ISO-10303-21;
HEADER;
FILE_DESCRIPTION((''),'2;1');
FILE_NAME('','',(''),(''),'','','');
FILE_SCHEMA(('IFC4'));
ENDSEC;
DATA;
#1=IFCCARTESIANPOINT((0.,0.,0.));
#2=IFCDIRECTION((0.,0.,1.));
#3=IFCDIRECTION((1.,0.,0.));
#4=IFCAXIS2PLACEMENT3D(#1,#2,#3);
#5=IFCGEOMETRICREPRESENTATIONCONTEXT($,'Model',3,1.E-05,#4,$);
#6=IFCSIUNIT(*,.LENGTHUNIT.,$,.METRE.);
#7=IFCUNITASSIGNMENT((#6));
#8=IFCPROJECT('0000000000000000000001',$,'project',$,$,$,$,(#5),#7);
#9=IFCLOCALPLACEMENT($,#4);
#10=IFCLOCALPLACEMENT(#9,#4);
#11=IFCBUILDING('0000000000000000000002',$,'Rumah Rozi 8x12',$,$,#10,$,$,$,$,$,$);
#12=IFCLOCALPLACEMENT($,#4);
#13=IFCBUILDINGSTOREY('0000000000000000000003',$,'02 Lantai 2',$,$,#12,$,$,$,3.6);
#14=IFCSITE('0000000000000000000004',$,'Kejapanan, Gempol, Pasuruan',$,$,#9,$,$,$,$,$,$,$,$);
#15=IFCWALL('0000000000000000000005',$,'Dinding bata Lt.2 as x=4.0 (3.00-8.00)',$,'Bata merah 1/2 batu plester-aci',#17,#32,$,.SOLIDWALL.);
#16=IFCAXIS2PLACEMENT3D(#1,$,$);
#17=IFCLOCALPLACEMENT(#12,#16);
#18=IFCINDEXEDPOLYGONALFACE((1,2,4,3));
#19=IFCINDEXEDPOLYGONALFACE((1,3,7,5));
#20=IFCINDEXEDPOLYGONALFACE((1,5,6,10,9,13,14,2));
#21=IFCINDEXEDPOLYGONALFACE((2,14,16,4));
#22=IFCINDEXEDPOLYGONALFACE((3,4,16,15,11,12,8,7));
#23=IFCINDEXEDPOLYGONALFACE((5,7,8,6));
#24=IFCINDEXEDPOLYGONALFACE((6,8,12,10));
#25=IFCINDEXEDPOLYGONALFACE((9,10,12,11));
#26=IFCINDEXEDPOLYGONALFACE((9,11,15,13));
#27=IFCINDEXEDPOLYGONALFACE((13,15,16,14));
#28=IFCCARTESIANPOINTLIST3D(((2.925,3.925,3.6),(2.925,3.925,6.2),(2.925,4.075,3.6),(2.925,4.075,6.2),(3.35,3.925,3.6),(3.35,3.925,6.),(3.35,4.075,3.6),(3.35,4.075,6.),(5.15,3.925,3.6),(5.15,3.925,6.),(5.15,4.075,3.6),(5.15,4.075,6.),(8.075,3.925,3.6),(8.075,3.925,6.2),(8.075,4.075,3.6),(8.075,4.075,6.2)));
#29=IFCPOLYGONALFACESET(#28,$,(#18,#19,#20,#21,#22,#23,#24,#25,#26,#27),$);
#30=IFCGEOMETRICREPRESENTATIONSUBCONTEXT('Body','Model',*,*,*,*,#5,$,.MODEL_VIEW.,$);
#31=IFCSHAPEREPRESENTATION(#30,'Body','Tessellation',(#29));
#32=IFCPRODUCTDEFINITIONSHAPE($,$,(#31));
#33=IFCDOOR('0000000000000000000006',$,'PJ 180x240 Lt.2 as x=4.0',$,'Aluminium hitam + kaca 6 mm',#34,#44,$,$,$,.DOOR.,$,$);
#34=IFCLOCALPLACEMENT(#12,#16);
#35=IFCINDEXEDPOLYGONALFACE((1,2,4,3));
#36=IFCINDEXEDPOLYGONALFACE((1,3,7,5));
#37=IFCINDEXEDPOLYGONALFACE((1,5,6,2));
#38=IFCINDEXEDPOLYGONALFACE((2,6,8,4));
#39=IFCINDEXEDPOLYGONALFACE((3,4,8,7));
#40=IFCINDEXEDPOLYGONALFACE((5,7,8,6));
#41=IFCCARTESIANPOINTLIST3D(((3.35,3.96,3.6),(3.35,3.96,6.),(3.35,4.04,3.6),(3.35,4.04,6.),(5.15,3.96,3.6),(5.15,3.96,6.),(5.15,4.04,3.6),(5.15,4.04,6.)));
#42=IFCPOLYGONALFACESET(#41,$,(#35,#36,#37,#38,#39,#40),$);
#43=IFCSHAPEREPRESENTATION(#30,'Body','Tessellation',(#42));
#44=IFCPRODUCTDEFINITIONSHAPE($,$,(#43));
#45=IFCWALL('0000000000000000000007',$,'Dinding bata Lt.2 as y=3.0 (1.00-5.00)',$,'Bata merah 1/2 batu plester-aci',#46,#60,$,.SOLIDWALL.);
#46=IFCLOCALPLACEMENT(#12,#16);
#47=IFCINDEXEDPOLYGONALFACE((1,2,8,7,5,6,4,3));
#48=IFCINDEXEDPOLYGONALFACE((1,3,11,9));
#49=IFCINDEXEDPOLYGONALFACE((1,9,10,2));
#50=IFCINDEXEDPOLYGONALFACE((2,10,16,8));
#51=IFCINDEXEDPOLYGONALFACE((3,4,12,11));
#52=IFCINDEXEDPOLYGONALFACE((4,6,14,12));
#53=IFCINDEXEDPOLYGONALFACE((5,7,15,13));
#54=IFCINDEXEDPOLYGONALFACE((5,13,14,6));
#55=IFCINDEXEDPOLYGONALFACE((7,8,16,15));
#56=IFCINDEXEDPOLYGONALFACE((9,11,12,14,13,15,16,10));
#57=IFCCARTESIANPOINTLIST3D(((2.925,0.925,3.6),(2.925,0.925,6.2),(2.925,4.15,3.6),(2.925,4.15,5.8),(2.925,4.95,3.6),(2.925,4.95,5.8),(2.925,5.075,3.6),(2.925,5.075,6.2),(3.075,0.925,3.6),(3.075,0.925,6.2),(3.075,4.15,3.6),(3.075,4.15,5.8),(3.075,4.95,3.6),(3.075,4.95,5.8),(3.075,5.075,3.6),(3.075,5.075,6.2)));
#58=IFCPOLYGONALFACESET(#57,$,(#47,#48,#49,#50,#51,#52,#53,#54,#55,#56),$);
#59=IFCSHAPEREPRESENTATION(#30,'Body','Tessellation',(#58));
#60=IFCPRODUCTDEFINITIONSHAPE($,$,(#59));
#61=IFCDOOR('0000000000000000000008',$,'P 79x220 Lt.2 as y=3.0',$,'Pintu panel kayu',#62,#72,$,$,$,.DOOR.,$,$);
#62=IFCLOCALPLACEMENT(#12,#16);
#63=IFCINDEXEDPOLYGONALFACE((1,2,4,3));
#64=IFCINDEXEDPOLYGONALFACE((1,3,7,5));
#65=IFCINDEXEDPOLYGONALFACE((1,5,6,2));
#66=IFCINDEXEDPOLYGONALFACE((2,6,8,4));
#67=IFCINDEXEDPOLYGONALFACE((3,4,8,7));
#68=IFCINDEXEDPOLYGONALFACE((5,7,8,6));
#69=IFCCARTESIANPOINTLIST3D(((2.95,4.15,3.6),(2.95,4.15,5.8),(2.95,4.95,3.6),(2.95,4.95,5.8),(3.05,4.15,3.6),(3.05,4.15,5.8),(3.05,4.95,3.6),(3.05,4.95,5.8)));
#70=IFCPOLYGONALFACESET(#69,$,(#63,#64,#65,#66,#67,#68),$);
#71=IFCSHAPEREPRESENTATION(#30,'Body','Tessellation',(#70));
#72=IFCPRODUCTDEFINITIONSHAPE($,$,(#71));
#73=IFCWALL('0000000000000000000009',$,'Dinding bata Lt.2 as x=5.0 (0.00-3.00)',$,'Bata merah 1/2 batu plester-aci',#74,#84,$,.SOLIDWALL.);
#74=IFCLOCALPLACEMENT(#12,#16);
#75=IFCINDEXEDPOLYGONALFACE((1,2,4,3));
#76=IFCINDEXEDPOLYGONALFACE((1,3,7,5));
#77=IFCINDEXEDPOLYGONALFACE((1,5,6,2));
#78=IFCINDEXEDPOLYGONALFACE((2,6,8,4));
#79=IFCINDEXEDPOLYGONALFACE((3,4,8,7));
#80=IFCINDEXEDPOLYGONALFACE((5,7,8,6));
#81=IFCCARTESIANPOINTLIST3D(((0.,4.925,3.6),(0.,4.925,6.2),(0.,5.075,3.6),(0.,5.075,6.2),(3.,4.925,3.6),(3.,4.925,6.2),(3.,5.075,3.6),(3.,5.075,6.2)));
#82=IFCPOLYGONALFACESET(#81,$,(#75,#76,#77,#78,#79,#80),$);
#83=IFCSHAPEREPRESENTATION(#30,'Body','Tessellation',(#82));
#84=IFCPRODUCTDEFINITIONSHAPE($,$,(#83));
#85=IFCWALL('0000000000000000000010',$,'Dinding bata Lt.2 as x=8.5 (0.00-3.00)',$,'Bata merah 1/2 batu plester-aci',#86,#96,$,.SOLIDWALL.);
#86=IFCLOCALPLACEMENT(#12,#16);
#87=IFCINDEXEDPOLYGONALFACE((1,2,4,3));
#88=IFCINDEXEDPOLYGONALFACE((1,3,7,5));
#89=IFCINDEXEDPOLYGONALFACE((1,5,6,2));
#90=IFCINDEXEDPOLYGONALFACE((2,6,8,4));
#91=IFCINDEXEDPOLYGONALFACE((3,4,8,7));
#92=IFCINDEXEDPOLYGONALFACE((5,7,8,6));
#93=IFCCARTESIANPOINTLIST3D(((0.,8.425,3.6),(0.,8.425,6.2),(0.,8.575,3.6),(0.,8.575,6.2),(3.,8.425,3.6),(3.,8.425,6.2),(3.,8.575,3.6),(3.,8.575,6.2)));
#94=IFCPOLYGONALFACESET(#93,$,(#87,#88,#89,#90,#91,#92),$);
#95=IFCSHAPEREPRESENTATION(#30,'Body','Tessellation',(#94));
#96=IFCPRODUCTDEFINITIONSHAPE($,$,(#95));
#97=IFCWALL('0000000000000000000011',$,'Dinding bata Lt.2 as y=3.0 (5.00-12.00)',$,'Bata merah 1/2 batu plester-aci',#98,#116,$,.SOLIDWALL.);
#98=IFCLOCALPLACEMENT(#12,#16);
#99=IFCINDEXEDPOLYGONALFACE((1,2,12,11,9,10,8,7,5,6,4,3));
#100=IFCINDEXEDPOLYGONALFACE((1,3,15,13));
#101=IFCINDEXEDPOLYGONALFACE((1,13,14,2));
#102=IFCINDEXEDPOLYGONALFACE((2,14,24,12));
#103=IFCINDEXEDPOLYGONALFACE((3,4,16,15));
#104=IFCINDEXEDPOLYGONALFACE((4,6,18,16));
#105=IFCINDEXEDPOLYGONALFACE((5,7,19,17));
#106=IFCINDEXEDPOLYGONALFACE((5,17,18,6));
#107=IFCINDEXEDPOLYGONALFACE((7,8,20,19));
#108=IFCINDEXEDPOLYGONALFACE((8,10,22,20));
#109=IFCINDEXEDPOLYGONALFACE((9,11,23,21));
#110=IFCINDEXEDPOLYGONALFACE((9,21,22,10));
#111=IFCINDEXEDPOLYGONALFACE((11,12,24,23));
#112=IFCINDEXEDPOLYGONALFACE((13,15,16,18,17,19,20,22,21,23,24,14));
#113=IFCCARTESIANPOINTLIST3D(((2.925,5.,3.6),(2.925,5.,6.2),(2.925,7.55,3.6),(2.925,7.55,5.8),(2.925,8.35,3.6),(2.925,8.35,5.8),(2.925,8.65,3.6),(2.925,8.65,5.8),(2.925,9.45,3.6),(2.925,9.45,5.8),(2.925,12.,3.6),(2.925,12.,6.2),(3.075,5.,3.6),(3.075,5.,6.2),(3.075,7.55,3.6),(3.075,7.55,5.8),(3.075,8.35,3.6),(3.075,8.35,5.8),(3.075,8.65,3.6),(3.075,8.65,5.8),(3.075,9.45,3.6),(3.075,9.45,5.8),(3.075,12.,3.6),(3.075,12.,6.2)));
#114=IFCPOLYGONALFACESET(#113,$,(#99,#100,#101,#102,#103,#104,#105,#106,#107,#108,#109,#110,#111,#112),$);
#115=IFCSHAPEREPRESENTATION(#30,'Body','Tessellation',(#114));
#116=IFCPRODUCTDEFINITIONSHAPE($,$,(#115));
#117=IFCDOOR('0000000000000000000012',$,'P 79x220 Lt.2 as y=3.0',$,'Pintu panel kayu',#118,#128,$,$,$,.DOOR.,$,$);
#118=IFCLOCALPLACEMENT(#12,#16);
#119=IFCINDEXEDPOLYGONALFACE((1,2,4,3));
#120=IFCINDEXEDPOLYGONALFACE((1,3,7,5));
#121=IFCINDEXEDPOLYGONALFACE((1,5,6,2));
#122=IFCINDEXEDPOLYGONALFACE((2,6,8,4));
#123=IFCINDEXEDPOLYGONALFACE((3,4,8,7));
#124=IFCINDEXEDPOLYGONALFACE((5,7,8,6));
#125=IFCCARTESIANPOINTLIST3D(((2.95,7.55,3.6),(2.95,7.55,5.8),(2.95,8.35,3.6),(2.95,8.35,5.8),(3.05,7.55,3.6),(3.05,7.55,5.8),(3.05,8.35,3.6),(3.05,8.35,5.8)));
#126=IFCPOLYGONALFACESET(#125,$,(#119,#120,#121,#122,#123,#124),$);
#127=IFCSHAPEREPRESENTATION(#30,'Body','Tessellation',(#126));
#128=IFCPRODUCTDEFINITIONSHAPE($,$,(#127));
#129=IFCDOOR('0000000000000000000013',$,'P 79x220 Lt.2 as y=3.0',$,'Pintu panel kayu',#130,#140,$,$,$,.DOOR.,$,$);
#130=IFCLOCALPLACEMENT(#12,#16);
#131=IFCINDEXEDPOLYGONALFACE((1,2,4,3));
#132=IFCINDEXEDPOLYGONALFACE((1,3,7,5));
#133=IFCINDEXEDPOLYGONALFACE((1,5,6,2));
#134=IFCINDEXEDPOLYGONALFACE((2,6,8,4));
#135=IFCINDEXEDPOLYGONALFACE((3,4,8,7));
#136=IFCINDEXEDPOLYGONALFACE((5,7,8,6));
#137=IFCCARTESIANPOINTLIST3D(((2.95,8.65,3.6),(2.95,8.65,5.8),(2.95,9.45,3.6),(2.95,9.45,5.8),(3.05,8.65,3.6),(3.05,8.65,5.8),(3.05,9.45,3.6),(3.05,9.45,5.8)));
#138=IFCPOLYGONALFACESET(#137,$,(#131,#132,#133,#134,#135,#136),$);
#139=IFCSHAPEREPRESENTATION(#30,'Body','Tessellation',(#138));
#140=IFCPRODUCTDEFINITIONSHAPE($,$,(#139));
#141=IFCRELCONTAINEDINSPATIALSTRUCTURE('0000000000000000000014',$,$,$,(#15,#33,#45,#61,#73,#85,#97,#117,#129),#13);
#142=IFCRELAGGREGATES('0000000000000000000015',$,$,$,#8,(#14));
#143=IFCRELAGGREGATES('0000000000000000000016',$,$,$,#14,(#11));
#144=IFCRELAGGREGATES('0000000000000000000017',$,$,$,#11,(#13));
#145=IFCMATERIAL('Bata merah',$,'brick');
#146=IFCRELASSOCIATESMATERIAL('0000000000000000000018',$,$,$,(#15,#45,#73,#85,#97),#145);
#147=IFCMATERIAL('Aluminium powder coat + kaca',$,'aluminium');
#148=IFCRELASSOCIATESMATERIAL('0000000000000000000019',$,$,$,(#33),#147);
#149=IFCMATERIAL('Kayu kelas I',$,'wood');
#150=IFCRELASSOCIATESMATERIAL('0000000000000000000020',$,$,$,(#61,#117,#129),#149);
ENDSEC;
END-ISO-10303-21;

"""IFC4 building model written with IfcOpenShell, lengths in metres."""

from ifc_helpers import new_model, si_unit, frame, origin_with_axes, place, context, subcontext, project, spatial, line, indexed_curve, outline, extrude, material, element, fill, save


model = new_model("IFC4")

# Units and contexts
model_context = context("Model", 3, precision=1e-05, world=origin_with_axes())
body_context = subcontext(model_context, "Body", "Model", "MODEL_VIEW")
ifc_project = project(units=[si_unit("LENGTHUNIT", "METRE")], contexts=[model_context])

# Site, building, storey
site_placement = place(None, origin_with_axes())
site = spatial("IfcSite", under=ifc_project, at=site_placement, Name="Kejapanan, Gempol, Pasuruan")
building_placement = place(site_placement, origin_with_axes())
building = spatial("IfcBuilding", under=site, at=building_placement, Name="Rumah Rozi 8x12")
storey_placement = place(None, origin_with_axes())
storey = spatial("IfcBuildingStorey", under=building, at=storey_placement, Name="02 Lantai 2", Elevation=3.6)

# Shared definitions
ifc_material_1 = material(Name="Bata merah", Category="brick")
ifc_material_2 = material(Name="Aluminium powder coat + kaca", Category="aluminium")

# Walls, openings, doors
wall_1_placement = place(storey_placement, origin_with_axes())
wall_1 = element("IfcWall", 1, at=wall_1_placement, inside=storey, material=ifc_material_1, Name="Dinding bata Lt.2 as x=4.0 (3.00-8.00)", ObjectType="Bata merah 1/2 batu plester-aci", PredefinedType="SOLIDWALL", context=body_context, shape_type="SweptSolid", body=[
    extrude(outline(indexed_curve([(2.925, 3.925), (8.075, 3.925), (8.075, 4.075), (2.925, 4.075)], segments=[line(1, 2, 3, 4, 1)])), frame((0.0, 0.0, 3.6), z_axis=(0.0, 0.0, 1.0), x_axis=(1.0, 0.0, 0.0)), (0.0, 0.0, 1.0), 2.6),
])
opening_1_placement = place(wall_1_placement, origin_with_axes())
opening_1 = element("IfcOpeningElement", 2, at=opening_1_placement, cuts=wall_1, context=body_context, shape_type="SweptSolid", body=[
    extrude(outline(indexed_curve([(3.35, 3.915), (5.15, 3.915), (5.15, 4.085), (3.35, 4.085)], segments=[line(1, 2, 3, 4, 1)])), frame((0.0, 0.0, 3.6), z_axis=(0.0, 0.0, 1.0), x_axis=(1.0, 0.0, 0.0)), (0.0, 0.0, 1.0), 2.4),
])
door_1_placement = place(storey_placement, origin_with_axes())
door_1 = element("IfcDoor", 3, at=door_1_placement, inside=storey, material=ifc_material_2, Name="PJ 180x240 Lt.2 as x=4.0", ObjectType="Aluminium hitam + kaca 6 mm", PredefinedType="DOOR", context=body_context, shape_type="SweptSolid", body=[
    extrude(outline(indexed_curve([(3.35, 3.96), (5.15, 3.96), (5.15, 4.04), (3.35, 4.04)], segments=[line(1, 2, 3, 4, 1)])), frame((0.0, 0.0, 3.6), z_axis=(0.0, 0.0, 1.0), x_axis=(1.0, 0.0, 0.0)), (0.0, 0.0, 1.0), 2.4),
])
fill(opening_1, door_1)
wall_2_placement = place(storey_placement, origin_with_axes())
wall_2 = element("IfcWall", 4, at=wall_2_placement, inside=storey, material=ifc_material_1, Name="Dinding bata Lt.2 as y=3.0 (1.00-5.00)", ObjectType="Bata merah 1/2 batu plester-aci", PredefinedType="SOLIDWALL", context=body_context, shape_type="SweptSolid", body=[
    extrude(outline(indexed_curve([(2.925, 0.925), (3.075, 0.925), (3.075, 5.075), (2.925, 5.075)], segments=[line(1, 2, 3, 4, 1)])), frame((0.0, 0.0, 3.6), z_axis=(0.0, 0.0, 1.0), x_axis=(1.0, 0.0, 0.0)), (0.0, 0.0, 1.0), 2.6),
])
opening_2_placement = place(wall_2_placement, origin_with_axes())
opening_2 = element("IfcOpeningElement", 5, at=opening_2_placement, cuts=wall_2, context=body_context, shape_type="SweptSolid", body=[
    extrude(outline(indexed_curve([(2.915, 4.15), (3.085, 4.15), (3.085, 4.95), (2.915, 4.95)], segments=[line(1, 2, 3, 4, 1)])), frame((0.0, 0.0, 3.6), z_axis=(0.0, 0.0, 1.0), x_axis=(1.0, 0.0, 0.0)), (0.0, 0.0, 1.0), 2.2),
])
ifc_material_3 = material(Name="Kayu kelas I", Category="wood")
door_2_placement = place(storey_placement, origin_with_axes())
door_2 = element("IfcDoor", 6, at=door_2_placement, inside=storey, material=ifc_material_3, Name="P 79x220 Lt.2 as y=3.0", ObjectType="Pintu panel kayu", PredefinedType="DOOR", context=body_context, shape_type="SweptSolid", body=[
    extrude(outline(indexed_curve([(2.95, 4.15), (3.05, 4.15), (3.05, 4.95), (2.95, 4.95)], segments=[line(1, 2, 3, 4, 1)])), frame((0.0, 0.0, 3.6), z_axis=(0.0, 0.0, 1.0), x_axis=(1.0, 0.0, 0.0)), (0.0, 0.0, 1.0), 2.2),
])
fill(opening_2, door_2)

# Walls
wall_3_placement = place(storey_placement, origin_with_axes())
element("IfcWall", 7, at=wall_3_placement, inside=storey, material=ifc_material_1, Name="Dinding bata Lt.2 as x=5.0 (0.00-3.00)", ObjectType="Bata merah 1/2 batu plester-aci", PredefinedType="SOLIDWALL", context=body_context, shape_type="SweptSolid", body=[
    extrude(outline(indexed_curve([(0.0, 4.925), (3.0, 4.925), (3.0, 5.075), (0.0, 5.075)], segments=[line(1, 2, 3, 4, 1)])), frame((0.0, 0.0, 3.6), z_axis=(0.0, 0.0, 1.0), x_axis=(1.0, 0.0, 0.0)), (0.0, 0.0, 1.0), 2.6),
])
wall_4_placement = place(storey_placement, origin_with_axes())
element("IfcWall", 8, at=wall_4_placement, inside=storey, material=ifc_material_1, Name="Dinding bata Lt.2 as x=8.5 (0.00-3.00)", ObjectType="Bata merah 1/2 batu plester-aci", PredefinedType="SOLIDWALL", context=body_context, shape_type="SweptSolid", body=[
    extrude(outline(indexed_curve([(0.0, 8.425), (3.0, 8.425), (3.0, 8.575), (0.0, 8.575)], segments=[line(1, 2, 3, 4, 1)])), frame((0.0, 0.0, 3.6), z_axis=(0.0, 0.0, 1.0), x_axis=(1.0, 0.0, 0.0)), (0.0, 0.0, 1.0), 2.6),
])

# Wall, openings, doors
wall_5_placement = place(storey_placement, origin_with_axes())
wall_5 = element("IfcWall", 9, at=wall_5_placement, inside=storey, material=ifc_material_1, Name="Dinding bata Lt.2 as y=3.0 (5.00-12.00)", ObjectType="Bata merah 1/2 batu plester-aci", PredefinedType="SOLIDWALL", context=body_context, shape_type="SweptSolid", body=[
    extrude(outline(indexed_curve([(2.925, 5.0), (3.075, 5.0), (3.075, 12.0), (2.925, 12.0)], segments=[line(1, 2, 3, 4, 1)])), frame((0.0, 0.0, 3.6), z_axis=(0.0, 0.0, 1.0), x_axis=(1.0, 0.0, 0.0)), (0.0, 0.0, 1.0), 2.6),
])
opening_3_placement = place(wall_5_placement, origin_with_axes())
opening_3 = element("IfcOpeningElement", 10, at=opening_3_placement, cuts=wall_5, context=body_context, shape_type="SweptSolid", body=[
    extrude(outline(indexed_curve([(2.915, 7.55), (3.085, 7.55), (3.085, 8.35), (2.915, 8.35)], segments=[line(1, 2, 3, 4, 1)])), frame((0.0, 0.0, 3.6), z_axis=(0.0, 0.0, 1.0), x_axis=(1.0, 0.0, 0.0)), (0.0, 0.0, 1.0), 2.2),
])
opening_4_placement = place(wall_5_placement, origin_with_axes())
opening_4 = element("IfcOpeningElement", 11, at=opening_4_placement, cuts=wall_5, context=body_context, shape_type="SweptSolid", body=[
    extrude(outline(indexed_curve([(2.915, 8.65), (3.085, 8.65), (3.085, 9.45), (2.915, 9.45)], segments=[line(1, 2, 3, 4, 1)])), frame((0.0, 0.0, 3.6), z_axis=(0.0, 0.0, 1.0), x_axis=(1.0, 0.0, 0.0)), (0.0, 0.0, 1.0), 2.2),
])
door_3_placement = place(storey_placement, origin_with_axes())
door_3 = element("IfcDoor", 12, at=door_3_placement, inside=storey, material=ifc_material_3, Name="P 79x220 Lt.2 as y=3.0", ObjectType="Pintu panel kayu", PredefinedType="DOOR", context=body_context, shape_type="SweptSolid", body=[
    extrude(outline(indexed_curve([(2.95, 7.55), (3.05, 7.55), (3.05, 8.35), (2.95, 8.35)], segments=[line(1, 2, 3, 4, 1)])), frame((0.0, 0.0, 3.6), z_axis=(0.0, 0.0, 1.0), x_axis=(1.0, 0.0, 0.0)), (0.0, 0.0, 1.0), 2.2),
])
fill(opening_3, door_3)
door_4_placement = place(storey_placement, origin_with_axes())
door_4 = element("IfcDoor", 13, at=door_4_placement, inside=storey, material=ifc_material_3, Name="P 79x220 Lt.2 as y=3.0", ObjectType="Pintu panel kayu", PredefinedType="DOOR", context=body_context, shape_type="SweptSolid", body=[
    extrude(outline(indexed_curve([(2.95, 8.65), (3.05, 8.65), (3.05, 9.45), (2.95, 9.45)], segments=[line(1, 2, 3, 4, 1)])), frame((0.0, 0.0, 3.6), z_axis=(0.0, 0.0, 1.0), x_axis=(1.0, 0.0, 0.0)), (0.0, 0.0, 1.0), 2.2),
])
fill(opening_4, door_4)

save(model, "model.ifc")
